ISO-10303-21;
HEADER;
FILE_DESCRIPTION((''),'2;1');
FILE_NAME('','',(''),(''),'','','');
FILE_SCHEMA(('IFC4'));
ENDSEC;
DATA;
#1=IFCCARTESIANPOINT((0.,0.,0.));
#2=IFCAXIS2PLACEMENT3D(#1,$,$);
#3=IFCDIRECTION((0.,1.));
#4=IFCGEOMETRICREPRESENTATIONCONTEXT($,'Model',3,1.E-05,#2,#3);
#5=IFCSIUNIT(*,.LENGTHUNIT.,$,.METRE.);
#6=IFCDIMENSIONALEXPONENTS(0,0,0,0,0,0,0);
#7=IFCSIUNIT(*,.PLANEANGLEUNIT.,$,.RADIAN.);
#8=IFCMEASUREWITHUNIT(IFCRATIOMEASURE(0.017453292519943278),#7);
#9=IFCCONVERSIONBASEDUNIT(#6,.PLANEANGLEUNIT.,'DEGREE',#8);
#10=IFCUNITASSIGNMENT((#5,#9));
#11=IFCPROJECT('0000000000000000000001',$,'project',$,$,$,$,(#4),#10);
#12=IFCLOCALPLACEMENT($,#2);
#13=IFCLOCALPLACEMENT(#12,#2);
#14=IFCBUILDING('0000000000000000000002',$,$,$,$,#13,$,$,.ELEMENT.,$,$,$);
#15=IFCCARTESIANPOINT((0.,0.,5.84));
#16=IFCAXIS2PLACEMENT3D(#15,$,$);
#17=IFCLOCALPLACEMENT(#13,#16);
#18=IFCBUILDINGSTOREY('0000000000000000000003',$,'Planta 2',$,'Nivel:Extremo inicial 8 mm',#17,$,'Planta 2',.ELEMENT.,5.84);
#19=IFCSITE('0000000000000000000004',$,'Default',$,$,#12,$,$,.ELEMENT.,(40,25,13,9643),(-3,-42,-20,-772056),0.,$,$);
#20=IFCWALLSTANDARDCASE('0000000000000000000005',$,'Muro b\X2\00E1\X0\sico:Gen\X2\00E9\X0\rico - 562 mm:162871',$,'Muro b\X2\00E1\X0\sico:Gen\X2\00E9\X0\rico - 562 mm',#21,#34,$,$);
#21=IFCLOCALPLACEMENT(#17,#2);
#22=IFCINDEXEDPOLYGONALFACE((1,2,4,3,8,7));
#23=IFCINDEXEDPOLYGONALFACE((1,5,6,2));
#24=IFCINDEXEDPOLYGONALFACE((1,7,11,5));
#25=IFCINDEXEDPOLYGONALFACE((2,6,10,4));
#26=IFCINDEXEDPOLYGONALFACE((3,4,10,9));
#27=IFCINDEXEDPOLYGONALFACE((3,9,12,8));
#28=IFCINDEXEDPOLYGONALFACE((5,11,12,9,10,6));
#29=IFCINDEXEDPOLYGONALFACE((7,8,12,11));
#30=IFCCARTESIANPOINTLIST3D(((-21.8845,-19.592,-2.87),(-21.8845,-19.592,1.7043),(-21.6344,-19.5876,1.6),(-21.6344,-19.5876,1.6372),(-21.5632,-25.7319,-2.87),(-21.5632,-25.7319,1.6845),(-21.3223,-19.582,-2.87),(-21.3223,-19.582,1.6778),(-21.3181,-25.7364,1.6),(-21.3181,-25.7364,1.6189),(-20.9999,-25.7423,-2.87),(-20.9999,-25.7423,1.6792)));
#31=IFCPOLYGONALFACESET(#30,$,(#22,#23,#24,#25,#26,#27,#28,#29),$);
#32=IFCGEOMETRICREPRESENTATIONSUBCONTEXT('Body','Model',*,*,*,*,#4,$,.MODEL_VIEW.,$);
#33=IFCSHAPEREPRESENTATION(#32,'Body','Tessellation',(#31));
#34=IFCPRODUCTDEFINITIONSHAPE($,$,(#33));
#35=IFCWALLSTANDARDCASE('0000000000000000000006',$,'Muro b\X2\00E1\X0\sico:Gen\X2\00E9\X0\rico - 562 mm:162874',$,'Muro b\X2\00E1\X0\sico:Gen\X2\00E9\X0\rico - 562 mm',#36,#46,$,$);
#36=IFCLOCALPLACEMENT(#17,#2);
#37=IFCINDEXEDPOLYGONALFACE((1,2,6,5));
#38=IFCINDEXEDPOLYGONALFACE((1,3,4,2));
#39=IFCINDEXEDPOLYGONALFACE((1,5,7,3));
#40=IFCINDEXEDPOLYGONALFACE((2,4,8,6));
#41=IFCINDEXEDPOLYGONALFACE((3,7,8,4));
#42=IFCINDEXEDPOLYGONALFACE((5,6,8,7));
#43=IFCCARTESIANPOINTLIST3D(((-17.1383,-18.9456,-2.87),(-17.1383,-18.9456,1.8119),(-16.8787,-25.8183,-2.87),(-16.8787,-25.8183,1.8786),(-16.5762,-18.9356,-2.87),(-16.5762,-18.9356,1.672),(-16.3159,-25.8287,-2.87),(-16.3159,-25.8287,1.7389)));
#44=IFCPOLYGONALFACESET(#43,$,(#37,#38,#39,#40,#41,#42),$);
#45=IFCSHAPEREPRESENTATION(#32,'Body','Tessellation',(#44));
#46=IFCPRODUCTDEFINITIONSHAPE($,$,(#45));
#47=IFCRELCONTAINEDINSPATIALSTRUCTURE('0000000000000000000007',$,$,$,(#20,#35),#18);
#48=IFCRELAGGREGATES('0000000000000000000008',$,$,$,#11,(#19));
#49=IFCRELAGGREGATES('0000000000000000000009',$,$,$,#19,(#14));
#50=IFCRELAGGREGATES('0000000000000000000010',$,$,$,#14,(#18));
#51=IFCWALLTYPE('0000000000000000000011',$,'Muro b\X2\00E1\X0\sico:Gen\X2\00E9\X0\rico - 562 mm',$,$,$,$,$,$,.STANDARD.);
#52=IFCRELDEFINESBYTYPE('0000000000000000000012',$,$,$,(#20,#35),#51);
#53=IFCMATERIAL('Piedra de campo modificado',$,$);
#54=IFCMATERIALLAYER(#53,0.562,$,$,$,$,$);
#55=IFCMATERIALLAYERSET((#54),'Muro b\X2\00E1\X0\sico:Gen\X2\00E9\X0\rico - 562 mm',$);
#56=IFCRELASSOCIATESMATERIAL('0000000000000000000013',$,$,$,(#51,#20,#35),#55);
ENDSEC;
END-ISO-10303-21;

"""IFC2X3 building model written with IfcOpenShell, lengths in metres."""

from ifc_helpers import new_model, entity, si_unit, converted_unit, direction, frame, origin, place, context, subcontext, project, spatial, polyline, outline, extrude, clip, bounded_halfspace, material, layer, layer_set, layer_usage, type_object, element, save


model = new_model("IFC2X3")

# Units and contexts
model_context = context("Model", 3, precision=1e-05, world=origin(), true_north=direction((0.0, 1.0)))
body_context = subcontext(model_context, "Body", "Model", "MODEL_VIEW")
ifc_project = project(units=[si_unit("LENGTHUNIT", "METRE"), converted_unit("PLANEANGLEUNIT", "DEGREE", entity("IfcRatioMeasure", 0.017453292519943278), si_unit("PLANEANGLEUNIT", "RADIAN"), dimensions=[0, 0, 0, 0, 0, 0, 0])], contexts=[model_context])

# Site, building, storey
site_placement = place(None, origin())
site = spatial("IfcSite", under=ifc_project, at=site_placement, Name="Default", CompositionType="ELEMENT", RefLatitude=(40, 25, 13, 9643), RefLongitude=(-3, -42, -20, -772056), RefElevation=0.0)
building_placement = place(site_placement, origin())
building = spatial("IfcBuilding", under=site, at=building_placement, CompositionType="ELEMENT")
storey_placement = place(building_placement, frame((0.0, 0.0, 5.84)))
storey = spatial("IfcBuildingStorey", under=building, at=storey_placement, Name="Planta 2", ObjectType="Nivel:Extremo inicial 8 mm", LongName="Planta 2", CompositionType="ELEMENT", Elevation=5.84)

# Walls
ifc_material_1 = material(Name="Piedra de campo modificado")
ifc_layer_1 = layer(ifc_material_1, 0.562)
ifc_layer_set_1 = layer_set([ifc_layer_1], Name="Muro básico:Genérico - 562 mm")
ifc_layer_usage_1 = layer_usage(ifc_layer_set_1, "AXIS2", "NEGATIVE", 0.281)
wall_type = type_object("IfcWallType", Name="Muro básico:Genérico - 562 mm", PredefinedType="STANDARD", material=ifc_layer_set_1)
wall_1_placement = place(storey_placement, frame((-21.6039, -19.5773, -2.87), z_axis=(0.0, 0.0, 1.0), x_axis=(0.052264, -0.998633, 0.0)))
element("IfcWallStandardCase", 1, at=wall_1_placement, inside=storey, type_object=wall_type, material=ifc_layer_usage_1, Name="Muro básico:Genérico - 562 mm:162871", ObjectType="Muro básico:Genérico - 562 mm", context=body_context, shape_type="Clipping", body=[
    clip(clip(extrude(outline(polyline([(6.1483, -0.281), (6.1881, 0.281), (0.0194, 0.281), (0.0, -0.281), (6.1483, -0.281)])), origin(), (0.0, 0.0, 1.0), 4.5743), bounded_halfspace(frame((6.1881, 0.281, 4.5492), z_axis=(-0.000218, -0.241922, 0.970296), x_axis=(1.0, -0.000901, 0.0)), False, frame((6.1881, 0.281, 4.5492)), polyline([(0.0, 0.0), (-6.1687, 0.0), (-6.1794, -0.3119), (-0.0225, -0.3175), (0.0, 0.0)]))), bounded_halfspace(frame((0.0, -0.281, 4.5743), z_axis=(0.003108, 0.2588, 0.965926), x_axis=(-0.999928, 0.012008, 0.0)), False, frame((0.0, -0.281, 4.5743)), polyline([(0.0, 0.0), (6.1483, 0.0), (6.1656, 0.2445), (0.0086, 0.2501), (0.0, 0.0)]))),
])
wall_2_placement = place(storey_placement, frame((-16.8575, -18.935, -2.87), z_axis=(0.0, 0.0, 1.0), x_axis=(0.037741, -0.999288, 0.0)))
element("IfcWallStandardCase", 2, at=wall_2_placement, inside=storey, type_object=wall_type, material=ifc_layer_usage_1, Name="Muro básico:Genérico - 562 mm:162874", ObjectType="Muro básico:Genérico - 562 mm", context=body_context, shape_type="Clipping", body=[
    clip(extrude(outline(polyline([(6.8776, -0.281), (6.9092, 0.281), (0.0112, 0.281), (0.0, -0.281), (6.8776, -0.281)])), origin(), (0.0, 0.0, 1.0), 4.7486), bounded_halfspace(frame((0.0, -0.281, 4.6819), z_axis=(-0.009402, 0.241739, 0.970296), x_axis=(-0.999244, -0.038865, 0.0)), False, frame((0.0, -0.281, 4.6819)), polyline([(0.0, 0.0), (6.8776, 0.0), (6.9092, 0.562), (0.0112, 0.562), (0.0, 0.0)]))),
])

save(model, "model.ifc")
